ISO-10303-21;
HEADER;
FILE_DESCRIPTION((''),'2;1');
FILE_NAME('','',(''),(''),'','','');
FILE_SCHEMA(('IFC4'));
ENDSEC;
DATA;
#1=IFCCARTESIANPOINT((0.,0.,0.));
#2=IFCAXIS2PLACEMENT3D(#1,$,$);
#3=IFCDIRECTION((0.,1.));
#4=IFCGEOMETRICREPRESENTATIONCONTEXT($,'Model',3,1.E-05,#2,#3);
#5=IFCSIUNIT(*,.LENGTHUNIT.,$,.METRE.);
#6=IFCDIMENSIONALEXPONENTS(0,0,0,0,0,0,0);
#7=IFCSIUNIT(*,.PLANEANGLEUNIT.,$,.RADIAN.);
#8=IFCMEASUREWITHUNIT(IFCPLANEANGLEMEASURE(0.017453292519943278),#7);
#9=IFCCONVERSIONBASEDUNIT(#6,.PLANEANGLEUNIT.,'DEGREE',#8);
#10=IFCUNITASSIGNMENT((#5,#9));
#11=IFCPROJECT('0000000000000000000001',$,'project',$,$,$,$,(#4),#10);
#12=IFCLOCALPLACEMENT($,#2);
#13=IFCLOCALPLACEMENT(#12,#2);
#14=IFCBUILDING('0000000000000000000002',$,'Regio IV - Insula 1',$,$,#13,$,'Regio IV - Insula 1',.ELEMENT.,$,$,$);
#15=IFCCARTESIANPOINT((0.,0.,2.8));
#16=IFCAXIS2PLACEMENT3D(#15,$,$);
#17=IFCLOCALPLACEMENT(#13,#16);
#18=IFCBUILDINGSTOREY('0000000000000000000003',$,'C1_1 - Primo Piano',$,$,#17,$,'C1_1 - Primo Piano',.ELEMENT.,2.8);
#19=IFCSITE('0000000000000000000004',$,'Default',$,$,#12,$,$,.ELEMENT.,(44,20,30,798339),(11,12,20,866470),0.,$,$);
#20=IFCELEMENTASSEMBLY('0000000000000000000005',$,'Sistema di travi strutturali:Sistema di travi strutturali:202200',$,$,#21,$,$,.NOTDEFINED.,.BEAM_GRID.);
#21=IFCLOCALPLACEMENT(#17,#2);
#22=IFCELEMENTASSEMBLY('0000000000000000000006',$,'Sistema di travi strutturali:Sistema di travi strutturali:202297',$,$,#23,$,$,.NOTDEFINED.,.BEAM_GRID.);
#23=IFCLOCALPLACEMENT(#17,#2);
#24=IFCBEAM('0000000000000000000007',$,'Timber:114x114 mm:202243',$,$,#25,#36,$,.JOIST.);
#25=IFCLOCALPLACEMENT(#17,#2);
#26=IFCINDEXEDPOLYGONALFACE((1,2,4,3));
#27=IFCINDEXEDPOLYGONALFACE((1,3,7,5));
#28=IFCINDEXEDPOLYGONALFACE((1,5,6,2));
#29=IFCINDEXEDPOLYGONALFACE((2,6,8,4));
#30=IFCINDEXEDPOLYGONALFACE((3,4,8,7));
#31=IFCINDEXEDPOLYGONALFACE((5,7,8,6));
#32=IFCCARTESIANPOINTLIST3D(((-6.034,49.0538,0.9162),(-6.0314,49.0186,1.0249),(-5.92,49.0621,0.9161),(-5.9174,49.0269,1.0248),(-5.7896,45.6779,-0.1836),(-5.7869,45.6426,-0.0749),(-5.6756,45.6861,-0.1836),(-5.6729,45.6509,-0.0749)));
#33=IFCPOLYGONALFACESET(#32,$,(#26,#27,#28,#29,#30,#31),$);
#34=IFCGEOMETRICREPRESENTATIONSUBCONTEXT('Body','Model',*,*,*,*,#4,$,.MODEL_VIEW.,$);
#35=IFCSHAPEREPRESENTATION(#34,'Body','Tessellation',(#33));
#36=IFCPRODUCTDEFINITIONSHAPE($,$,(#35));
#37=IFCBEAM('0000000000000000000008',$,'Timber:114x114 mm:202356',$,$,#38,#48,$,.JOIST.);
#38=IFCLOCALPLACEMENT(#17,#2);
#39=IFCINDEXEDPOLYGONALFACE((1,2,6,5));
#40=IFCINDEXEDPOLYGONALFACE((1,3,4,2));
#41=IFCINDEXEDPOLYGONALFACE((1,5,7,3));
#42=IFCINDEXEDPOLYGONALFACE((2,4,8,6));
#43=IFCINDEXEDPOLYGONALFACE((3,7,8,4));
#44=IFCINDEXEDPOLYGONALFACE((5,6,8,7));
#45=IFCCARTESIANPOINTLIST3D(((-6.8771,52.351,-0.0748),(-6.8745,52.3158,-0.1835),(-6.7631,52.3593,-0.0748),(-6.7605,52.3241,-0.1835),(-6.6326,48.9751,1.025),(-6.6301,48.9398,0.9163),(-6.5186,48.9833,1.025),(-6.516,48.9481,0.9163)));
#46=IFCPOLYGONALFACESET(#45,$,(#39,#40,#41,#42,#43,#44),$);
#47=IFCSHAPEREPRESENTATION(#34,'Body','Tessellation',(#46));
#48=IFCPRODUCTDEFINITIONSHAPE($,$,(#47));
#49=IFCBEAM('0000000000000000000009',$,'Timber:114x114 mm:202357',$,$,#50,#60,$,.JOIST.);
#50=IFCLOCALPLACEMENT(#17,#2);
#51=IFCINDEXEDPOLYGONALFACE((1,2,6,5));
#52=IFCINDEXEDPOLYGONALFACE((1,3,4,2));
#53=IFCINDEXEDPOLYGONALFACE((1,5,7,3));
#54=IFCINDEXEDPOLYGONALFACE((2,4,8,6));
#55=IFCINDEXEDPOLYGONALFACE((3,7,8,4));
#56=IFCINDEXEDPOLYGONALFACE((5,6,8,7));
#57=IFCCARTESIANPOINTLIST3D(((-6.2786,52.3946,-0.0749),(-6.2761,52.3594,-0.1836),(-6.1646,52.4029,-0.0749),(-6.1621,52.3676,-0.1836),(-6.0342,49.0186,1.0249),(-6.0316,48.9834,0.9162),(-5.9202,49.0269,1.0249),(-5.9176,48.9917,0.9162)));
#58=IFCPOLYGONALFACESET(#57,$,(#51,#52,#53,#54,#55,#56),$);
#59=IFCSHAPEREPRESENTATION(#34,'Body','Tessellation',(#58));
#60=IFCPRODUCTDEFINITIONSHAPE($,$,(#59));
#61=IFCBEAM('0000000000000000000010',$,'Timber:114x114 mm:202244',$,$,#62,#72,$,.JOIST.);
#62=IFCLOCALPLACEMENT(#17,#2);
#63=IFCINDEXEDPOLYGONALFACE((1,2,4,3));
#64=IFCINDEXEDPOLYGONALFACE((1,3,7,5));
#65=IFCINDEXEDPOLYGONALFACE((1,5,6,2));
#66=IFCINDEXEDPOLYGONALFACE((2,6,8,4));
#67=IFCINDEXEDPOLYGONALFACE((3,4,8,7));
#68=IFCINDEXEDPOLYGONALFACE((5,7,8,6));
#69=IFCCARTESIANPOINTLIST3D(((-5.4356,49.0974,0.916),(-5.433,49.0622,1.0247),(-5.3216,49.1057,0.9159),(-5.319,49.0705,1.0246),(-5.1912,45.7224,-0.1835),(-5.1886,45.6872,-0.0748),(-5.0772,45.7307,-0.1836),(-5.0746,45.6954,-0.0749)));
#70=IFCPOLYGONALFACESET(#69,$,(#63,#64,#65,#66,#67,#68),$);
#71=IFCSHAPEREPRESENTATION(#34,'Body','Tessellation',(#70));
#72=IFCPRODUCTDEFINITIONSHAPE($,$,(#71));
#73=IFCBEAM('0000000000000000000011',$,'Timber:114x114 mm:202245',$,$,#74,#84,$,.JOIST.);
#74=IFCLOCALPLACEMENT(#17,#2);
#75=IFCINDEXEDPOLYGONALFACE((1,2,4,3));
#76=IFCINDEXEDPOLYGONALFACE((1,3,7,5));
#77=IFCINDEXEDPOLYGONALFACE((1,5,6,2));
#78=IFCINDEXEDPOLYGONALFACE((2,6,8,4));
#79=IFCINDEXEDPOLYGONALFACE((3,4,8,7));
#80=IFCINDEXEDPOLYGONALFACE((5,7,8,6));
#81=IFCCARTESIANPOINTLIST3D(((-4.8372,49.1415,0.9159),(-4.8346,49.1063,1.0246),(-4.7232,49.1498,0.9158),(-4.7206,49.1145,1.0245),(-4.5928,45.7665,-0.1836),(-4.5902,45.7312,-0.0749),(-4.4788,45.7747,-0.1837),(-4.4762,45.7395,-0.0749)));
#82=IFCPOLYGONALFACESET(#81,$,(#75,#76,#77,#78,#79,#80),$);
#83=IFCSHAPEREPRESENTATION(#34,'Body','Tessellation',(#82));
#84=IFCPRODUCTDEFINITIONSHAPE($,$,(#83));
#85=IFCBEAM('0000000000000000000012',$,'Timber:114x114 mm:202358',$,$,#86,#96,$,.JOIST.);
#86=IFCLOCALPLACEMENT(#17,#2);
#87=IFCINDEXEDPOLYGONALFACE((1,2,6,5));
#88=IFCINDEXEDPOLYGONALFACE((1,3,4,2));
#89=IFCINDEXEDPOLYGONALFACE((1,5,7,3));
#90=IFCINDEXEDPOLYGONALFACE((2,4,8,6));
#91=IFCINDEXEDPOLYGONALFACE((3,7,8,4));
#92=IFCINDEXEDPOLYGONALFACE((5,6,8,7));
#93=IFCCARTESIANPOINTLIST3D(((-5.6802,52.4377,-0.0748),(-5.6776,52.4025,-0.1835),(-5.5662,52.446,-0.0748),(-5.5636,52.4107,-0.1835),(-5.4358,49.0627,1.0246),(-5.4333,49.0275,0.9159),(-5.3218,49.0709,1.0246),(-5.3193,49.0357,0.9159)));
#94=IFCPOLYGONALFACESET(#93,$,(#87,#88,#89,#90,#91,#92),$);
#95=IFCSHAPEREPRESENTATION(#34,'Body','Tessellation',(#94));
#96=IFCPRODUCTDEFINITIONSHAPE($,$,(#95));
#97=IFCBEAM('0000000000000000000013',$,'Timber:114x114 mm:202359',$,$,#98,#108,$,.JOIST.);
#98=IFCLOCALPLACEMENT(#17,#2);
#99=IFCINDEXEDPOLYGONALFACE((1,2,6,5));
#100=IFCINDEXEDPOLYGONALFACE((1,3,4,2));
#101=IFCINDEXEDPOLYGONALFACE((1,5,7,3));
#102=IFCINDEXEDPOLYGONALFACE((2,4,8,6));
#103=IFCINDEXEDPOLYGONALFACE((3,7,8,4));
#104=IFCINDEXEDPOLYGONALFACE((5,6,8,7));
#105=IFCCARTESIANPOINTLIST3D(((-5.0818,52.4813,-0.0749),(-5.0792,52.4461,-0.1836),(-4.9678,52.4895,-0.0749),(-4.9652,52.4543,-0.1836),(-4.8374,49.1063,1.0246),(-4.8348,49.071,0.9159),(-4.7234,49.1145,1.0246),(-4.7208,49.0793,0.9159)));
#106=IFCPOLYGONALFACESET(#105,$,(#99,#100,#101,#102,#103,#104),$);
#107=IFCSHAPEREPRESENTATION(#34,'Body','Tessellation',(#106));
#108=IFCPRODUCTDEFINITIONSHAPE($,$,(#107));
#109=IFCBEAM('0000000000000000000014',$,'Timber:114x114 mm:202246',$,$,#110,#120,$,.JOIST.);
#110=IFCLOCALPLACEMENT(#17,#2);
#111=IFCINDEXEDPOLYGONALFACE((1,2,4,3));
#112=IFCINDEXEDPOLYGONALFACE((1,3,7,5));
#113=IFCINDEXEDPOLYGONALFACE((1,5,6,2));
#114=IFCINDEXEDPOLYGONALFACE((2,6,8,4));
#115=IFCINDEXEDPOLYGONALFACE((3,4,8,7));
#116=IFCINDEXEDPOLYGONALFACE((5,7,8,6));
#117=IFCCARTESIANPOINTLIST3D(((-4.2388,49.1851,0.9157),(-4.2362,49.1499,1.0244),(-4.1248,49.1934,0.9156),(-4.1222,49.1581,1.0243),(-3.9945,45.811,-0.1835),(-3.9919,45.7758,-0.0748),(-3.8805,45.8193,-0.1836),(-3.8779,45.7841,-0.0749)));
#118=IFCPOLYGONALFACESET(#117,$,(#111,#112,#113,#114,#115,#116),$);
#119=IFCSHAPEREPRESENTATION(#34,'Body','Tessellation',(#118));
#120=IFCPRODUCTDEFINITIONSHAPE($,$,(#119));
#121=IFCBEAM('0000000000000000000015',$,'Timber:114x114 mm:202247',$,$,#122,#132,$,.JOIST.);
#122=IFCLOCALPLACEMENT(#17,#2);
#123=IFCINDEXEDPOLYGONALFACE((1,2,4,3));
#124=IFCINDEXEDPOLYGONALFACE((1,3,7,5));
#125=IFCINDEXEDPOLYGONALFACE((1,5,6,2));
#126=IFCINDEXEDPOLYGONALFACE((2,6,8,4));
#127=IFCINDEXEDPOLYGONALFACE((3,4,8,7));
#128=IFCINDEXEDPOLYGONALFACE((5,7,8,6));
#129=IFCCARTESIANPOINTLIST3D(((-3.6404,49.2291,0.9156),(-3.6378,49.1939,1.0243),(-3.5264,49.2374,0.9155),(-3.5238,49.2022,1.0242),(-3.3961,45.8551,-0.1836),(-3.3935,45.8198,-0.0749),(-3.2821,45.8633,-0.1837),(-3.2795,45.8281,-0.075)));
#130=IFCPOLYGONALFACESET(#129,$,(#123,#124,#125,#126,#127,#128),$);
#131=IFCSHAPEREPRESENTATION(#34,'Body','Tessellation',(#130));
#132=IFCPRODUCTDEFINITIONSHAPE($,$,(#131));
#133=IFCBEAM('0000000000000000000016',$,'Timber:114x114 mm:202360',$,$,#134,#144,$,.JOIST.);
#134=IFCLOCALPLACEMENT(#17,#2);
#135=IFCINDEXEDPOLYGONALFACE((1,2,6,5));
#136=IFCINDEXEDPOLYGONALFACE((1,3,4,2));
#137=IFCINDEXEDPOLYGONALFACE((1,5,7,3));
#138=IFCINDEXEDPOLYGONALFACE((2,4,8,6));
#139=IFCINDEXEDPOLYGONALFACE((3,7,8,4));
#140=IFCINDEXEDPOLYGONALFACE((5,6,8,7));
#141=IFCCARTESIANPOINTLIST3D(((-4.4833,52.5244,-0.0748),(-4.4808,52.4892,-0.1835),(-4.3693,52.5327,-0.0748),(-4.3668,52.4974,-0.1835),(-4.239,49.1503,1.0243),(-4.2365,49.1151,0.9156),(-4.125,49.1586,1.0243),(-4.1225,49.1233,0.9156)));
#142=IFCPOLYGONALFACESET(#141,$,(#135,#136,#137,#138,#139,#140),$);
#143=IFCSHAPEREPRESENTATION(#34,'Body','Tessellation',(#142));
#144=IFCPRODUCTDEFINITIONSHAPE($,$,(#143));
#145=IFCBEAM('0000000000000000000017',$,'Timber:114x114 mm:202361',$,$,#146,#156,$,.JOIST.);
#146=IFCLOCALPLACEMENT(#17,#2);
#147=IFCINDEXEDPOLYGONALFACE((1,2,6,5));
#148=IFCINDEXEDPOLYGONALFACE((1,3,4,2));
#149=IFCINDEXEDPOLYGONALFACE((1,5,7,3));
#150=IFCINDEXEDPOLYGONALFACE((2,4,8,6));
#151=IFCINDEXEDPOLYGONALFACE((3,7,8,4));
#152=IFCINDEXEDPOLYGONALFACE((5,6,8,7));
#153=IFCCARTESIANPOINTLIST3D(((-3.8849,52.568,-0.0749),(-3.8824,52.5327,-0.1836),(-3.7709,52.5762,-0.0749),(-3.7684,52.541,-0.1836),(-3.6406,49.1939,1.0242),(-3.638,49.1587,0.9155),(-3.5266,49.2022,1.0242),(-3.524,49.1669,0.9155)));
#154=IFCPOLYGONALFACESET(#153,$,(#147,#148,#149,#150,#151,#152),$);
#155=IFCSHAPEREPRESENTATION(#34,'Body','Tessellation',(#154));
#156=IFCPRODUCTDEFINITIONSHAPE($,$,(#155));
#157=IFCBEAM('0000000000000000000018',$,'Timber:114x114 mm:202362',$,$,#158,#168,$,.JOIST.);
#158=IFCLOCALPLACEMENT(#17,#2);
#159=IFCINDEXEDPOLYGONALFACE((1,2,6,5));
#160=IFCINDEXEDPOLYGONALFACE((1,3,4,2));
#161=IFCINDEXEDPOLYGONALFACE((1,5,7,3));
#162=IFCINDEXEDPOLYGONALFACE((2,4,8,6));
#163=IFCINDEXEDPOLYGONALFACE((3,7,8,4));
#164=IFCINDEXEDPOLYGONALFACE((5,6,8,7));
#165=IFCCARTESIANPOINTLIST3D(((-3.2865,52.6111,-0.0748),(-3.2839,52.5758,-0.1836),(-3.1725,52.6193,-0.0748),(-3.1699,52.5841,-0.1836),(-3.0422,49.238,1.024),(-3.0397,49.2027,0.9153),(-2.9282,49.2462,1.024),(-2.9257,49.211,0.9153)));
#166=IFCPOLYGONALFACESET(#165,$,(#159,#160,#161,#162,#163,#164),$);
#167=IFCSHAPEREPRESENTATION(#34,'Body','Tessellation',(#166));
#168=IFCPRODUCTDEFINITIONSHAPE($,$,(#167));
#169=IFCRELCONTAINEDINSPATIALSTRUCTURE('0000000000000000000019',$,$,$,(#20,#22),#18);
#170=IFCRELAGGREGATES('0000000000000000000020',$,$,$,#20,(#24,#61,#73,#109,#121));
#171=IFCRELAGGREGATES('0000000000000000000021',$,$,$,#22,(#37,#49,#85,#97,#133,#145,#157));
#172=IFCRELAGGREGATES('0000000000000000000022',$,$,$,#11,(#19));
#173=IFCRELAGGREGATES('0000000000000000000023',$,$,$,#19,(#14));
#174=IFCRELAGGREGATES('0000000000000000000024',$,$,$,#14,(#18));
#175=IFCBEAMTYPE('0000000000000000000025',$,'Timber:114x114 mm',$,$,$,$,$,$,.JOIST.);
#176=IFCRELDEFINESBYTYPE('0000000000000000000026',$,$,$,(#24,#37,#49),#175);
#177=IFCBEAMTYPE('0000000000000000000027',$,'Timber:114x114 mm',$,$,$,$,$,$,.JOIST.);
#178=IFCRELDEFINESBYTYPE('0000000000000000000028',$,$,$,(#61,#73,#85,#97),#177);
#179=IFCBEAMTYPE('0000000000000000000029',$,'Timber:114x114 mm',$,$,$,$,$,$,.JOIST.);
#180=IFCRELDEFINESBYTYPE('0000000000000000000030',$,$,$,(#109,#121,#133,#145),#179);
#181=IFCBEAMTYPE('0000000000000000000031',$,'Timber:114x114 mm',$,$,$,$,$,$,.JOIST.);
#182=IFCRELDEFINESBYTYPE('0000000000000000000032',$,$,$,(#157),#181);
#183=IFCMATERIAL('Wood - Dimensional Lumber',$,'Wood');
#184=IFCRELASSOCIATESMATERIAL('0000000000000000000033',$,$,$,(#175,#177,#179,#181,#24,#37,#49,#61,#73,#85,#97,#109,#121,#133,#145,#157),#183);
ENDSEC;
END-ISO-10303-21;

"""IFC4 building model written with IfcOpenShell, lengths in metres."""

from ifc_helpers import new_model, entity, si_unit, converted_unit, direction, frame, origin, origin_2d_with_axis, place, context, subcontext, project, spatial, rectangle, extrude, source, transform, mapped, material, material_profile, profile_set, profile_usage, type_object, type_shapes, element, aggregate, save


model = new_model("IFC4")

# Units and contexts
model_context = context("Model", 3, precision=1e-05, world=origin(), true_north=direction((0.0, 1.0)))
body_context = subcontext(model_context, "Body", "Model", "MODEL_VIEW")
ifc_project = project(units=[si_unit("LENGTHUNIT", "METRE"), converted_unit("PLANEANGLEUNIT", "DEGREE", entity("IfcPlaneAngleMeasure", 0.017453292519943278), si_unit("PLANEANGLEUNIT", "RADIAN"), dimensions=[0, 0, 0, 0, 0, 0, 0])], contexts=[model_context])

# Site, building, storey
site_placement = place(None, origin())
site = spatial("IfcSite", under=ifc_project, at=site_placement, Name="Default", CompositionType="ELEMENT", RefLatitude=(44, 20, 30, 798339), RefLongitude=(11, 12, 20, 866470), RefElevation=0.0)
building_placement = place(site_placement, origin())
building = spatial("IfcBuilding", under=site, at=building_placement, Name="Regio IV - Insula 1", LongName="Regio IV - Insula 1", CompositionType="ELEMENT")
storey_placement = place(building_placement, frame((0.0, 0.0, 2.8)))
storey = spatial("IfcBuildingStorey", under=building, at=storey_placement, Name="C1_1 - Primo Piano", LongName="C1_1 - Primo Piano", CompositionType="ELEMENT", Elevation=2.8)

# Element assemblies
assembly_1_placement = place(storey_placement, origin())
assembly_1 = element("IfcElementAssembly", 1, at=assembly_1_placement, inside=storey, Name="Sistema di travi strutturali:Sistema di travi strutturali:202200", AssemblyPlace="NOTDEFINED", PredefinedType="BEAM_GRID")
ifc_material = material(Name="Wood - Dimensional Lumber", Category="Wood")
ifc_material_profile = material_profile(ifc_material, rectangle(XDim=5.294, YDim=0.1143, at=origin_2d_with_axis()), Name="114x114 mm")
ifc_profile_set = profile_set([ifc_material_profile], Name="114x114 mm")
ifc_profile_usage = profile_usage(ifc_profile_set, cardinal=8)
assembly_2_placement = place(storey_placement, origin())
assembly_2 = element("IfcElementAssembly", 2, at=assembly_2_placement, inside=storey, Name="Sistema di travi strutturali:Sistema di travi strutturali:202297", AssemblyPlace="NOTDEFINED", PredefinedType="BEAM_GRID")

# Beams
beam_type_1 = type_object("IfcBeamType", Name="Timber:114x114 mm", PredefinedType="JOIST", material=ifc_profile_set)
shared_shape_1 = source(origin(), body_context, "Body", "SweptSolid", [
    extrude(rectangle(XDim=3.559, YDim=0.1143, at=origin_2d_with_axis()), frame((0.0, 0.0, -0.0572), z_axis=(0.0, 0.0, 1.0), x_axis=(-1.0, 0.0, 0.0)), (0.0, 0.0, 1.0), 0.1143),
])
type_shapes(beam_type_1, [shared_shape_1])
beam_1_placement = place(assembly_1_placement, frame((-5.8535, 47.3524, 0.4206), z_axis=(0.022823, -0.308173, 0.951057), x_axis=(0.068685, -0.948573, -0.309017)))
beam_1 = element("IfcBeam", 3, at=beam_1_placement, type_object=beam_type_1, material=ifc_profile_usage, Name="Timber:114x114 mm:202243", PredefinedType="JOIST", context=body_context, shape_type="MappedRepresentation", body=[
    mapped(shared_shape_1, transform((0.0, 0.0, 0.0), scale=1.0)),
])
beam_2_placement = place(assembly_2_placement, frame((-6.6966, 50.6496, 0.4207), z_axis=(-0.022317, 0.30821, 0.951057), x_axis=(0.068685, -0.948573, 0.309017)))
beam_2 = element("IfcBeam", 4, at=beam_2_placement, type_object=beam_type_1, material=ifc_profile_usage, Name="Timber:114x114 mm:202356", PredefinedType="JOIST", context=body_context, shape_type="MappedRepresentation", body=[
    mapped(shared_shape_1, transform((0.0, 0.0, 0.0), scale=1.0)),
])
beam_3_placement = place(assembly_2_placement, frame((-6.0981, 50.6931, 0.4206), z_axis=(-0.022317, 0.30821, 0.951057), x_axis=(0.068685, -0.948573, 0.309017)))
beam_3 = element("IfcBeam", 5, at=beam_3_placement, type_object=beam_type_1, material=ifc_profile_usage, Name="Timber:114x114 mm:202357", PredefinedType="JOIST", context=body_context, shape_type="MappedRepresentation", body=[
    mapped(shared_shape_1, transform((0.0, 0.0, 0.0), scale=1.0)),
])
beam_type_2 = type_object("IfcBeamType", Name="Timber:114x114 mm", PredefinedType="JOIST", material=ifc_profile_set)
shared_shape_2 = source(origin(), body_context, "Body", "SweptSolid", [
    extrude(rectangle(XDim=3.558, YDim=0.1143, at=origin_2d_with_axis()), frame((0.0, 0.0, -0.0572), z_axis=(0.0, 0.0, 1.0), x_axis=(-1.0, 0.0, 0.0)), (0.0, 0.0, 1.0), 0.1143),
])
type_shapes(beam_type_2, [shared_shape_2])
beam_4_placement = place(assembly_1_placement, frame((-5.2551, 47.3964, 0.4205), z_axis=(0.022823, -0.308173, 0.951057), x_axis=(0.068685, -0.948573, -0.309017)))
beam_4 = element("IfcBeam", 6, at=beam_4_placement, type_object=beam_type_2, material=ifc_profile_usage, Name="Timber:114x114 mm:202244", PredefinedType="JOIST", context=body_context, shape_type="MappedRepresentation", body=[
    mapped(shared_shape_2, transform((0.0, 0.0, 0.0), scale=1.0)),
])
beam_5_placement = place(assembly_1_placement, frame((-4.6567, 47.4405, 0.4205), z_axis=(0.022823, -0.308173, 0.951057), x_axis=(0.068685, -0.948573, -0.309017)))
beam_5 = element("IfcBeam", 7, at=beam_5_placement, type_object=beam_type_2, material=ifc_profile_usage, Name="Timber:114x114 mm:202245", PredefinedType="JOIST", context=body_context, shape_type="MappedRepresentation", body=[
    mapped(shared_shape_2, transform((0.0, 0.0, 0.0), scale=1.0)),
])
beam_6_placement = place(assembly_2_placement, frame((-5.4997, 50.7367, 0.4205), z_axis=(-0.022317, 0.30821, 0.951057), x_axis=(0.068685, -0.948573, 0.309017)))
beam_6 = element("IfcBeam", 8, at=beam_6_placement, type_object=beam_type_2, material=ifc_profile_usage, Name="Timber:114x114 mm:202358", PredefinedType="JOIST", context=body_context, shape_type="MappedRepresentation", body=[
    mapped(shared_shape_2, transform((0.0, 0.0, 0.0), scale=1.0)),
])
beam_7_placement = place(assembly_2_placement, frame((-4.9013, 50.7803, 0.4205), z_axis=(-0.022317, 0.30821, 0.951057), x_axis=(0.068685, -0.948573, 0.309017)))
beam_7 = element("IfcBeam", 9, at=beam_7_placement, type_object=beam_type_2, material=ifc_profile_usage, Name="Timber:114x114 mm:202359", PredefinedType="JOIST", context=body_context, shape_type="MappedRepresentation", body=[
    mapped(shared_shape_2, transform((0.0, 0.0, 0.0), scale=1.0)),
])
beam_type_3 = type_object("IfcBeamType", Name="Timber:114x114 mm", PredefinedType="JOIST", material=ifc_profile_set)
shared_shape_3 = source(origin(), body_context, "Body", "SweptSolid", [
    extrude(rectangle(XDim=3.557, YDim=0.1143, at=origin_2d_with_axis()), frame((0.0, 0.0, -0.0572), z_axis=(0.0, 0.0, 1.0), x_axis=(-1.0, 0.0, 0.0)), (0.0, 0.0, 1.0), 0.1143),
])
type_shapes(beam_type_3, [shared_shape_3])
beam_8_placement = place(assembly_1_placement, frame((-4.0583, 47.4846, 0.4204), z_axis=(0.022823, -0.308173, 0.951057), x_axis=(0.068685, -0.948573, -0.309017)))
beam_8 = element("IfcBeam", 10, at=beam_8_placement, type_object=beam_type_3, material=ifc_profile_usage, Name="Timber:114x114 mm:202246", PredefinedType="JOIST", context=body_context, shape_type="MappedRepresentation", body=[
    mapped(shared_shape_3, transform((0.0, 0.0, 0.0), scale=1.0)),
])
beam_9_placement = place(assembly_1_placement, frame((-3.46, 47.5286, 0.4203), z_axis=(0.022823, -0.308173, 0.951057), x_axis=(0.068685, -0.948573, -0.309017)))
beam_9 = element("IfcBeam", 11, at=beam_9_placement, type_object=beam_type_3, material=ifc_profile_usage, Name="Timber:114x114 mm:202247", PredefinedType="JOIST", context=body_context, shape_type="MappedRepresentation", body=[
    mapped(shared_shape_3, transform((0.0, 0.0, 0.0), scale=1.0)),
])
aggregate(assembly_1, [beam_1, beam_4, beam_5, beam_8, beam_9])
beam_10_placement = place(assembly_2_placement, frame((-4.3029, 50.8239, 0.4204), z_axis=(-0.022317, 0.30821, 0.951057), x_axis=(0.068685, -0.948573, 0.309017)))
beam_10 = element("IfcBeam", 12, at=beam_10_placement, type_object=beam_type_3, material=ifc_profile_usage, Name="Timber:114x114 mm:202360", PredefinedType="JOIST", context=body_context, shape_type="MappedRepresentation", body=[
    mapped(shared_shape_3, transform((0.0, 0.0, 0.0), scale=1.0)),
])
beam_11_placement = place(assembly_2_placement, frame((-3.7045, 50.8675, 0.4203), z_axis=(-0.022317, 0.30821, 0.951057), x_axis=(0.068685, -0.948573, 0.309017)))
beam_11 = element("IfcBeam", 13, at=beam_11_placement, type_object=beam_type_3, material=ifc_profile_usage, Name="Timber:114x114 mm:202361", PredefinedType="JOIST", context=body_context, shape_type="MappedRepresentation", body=[
    mapped(shared_shape_3, transform((0.0, 0.0, 0.0), scale=1.0)),
])
beam_type_4 = type_object("IfcBeamType", Name="Timber:114x114 mm", PredefinedType="JOIST", material=ifc_profile_set)
shared_shape_4 = source(origin(), body_context, "Body", "SweptSolid", [
    extrude(rectangle(XDim=3.556, YDim=0.1143, at=origin_2d_with_axis()), frame((0.0, 0.0, -0.0572), z_axis=(0.0, 0.0, 1.0), x_axis=(-1.0, 0.0, 0.0)), (0.0, 0.0, 1.0), 0.1143),
])
type_shapes(beam_type_4, [shared_shape_4])
beam_12_placement = place(assembly_2_placement, frame((-3.1061, 50.911, 0.4202), z_axis=(-0.022317, 0.30821, 0.951057), x_axis=(0.068685, -0.948573, 0.309017)))
beam_12 = element("IfcBeam", 14, at=beam_12_placement, type_object=beam_type_4, material=ifc_profile_usage, Name="Timber:114x114 mm:202362", PredefinedType="JOIST", context=body_context, shape_type="MappedRepresentation", body=[
    mapped(shared_shape_4, transform((0.0, 0.0, 0.0), scale=1.0)),
])
aggregate(assembly_2, [beam_2, beam_3, beam_6, beam_7, beam_10, beam_11, beam_12])

save(model, "model.ifc")
